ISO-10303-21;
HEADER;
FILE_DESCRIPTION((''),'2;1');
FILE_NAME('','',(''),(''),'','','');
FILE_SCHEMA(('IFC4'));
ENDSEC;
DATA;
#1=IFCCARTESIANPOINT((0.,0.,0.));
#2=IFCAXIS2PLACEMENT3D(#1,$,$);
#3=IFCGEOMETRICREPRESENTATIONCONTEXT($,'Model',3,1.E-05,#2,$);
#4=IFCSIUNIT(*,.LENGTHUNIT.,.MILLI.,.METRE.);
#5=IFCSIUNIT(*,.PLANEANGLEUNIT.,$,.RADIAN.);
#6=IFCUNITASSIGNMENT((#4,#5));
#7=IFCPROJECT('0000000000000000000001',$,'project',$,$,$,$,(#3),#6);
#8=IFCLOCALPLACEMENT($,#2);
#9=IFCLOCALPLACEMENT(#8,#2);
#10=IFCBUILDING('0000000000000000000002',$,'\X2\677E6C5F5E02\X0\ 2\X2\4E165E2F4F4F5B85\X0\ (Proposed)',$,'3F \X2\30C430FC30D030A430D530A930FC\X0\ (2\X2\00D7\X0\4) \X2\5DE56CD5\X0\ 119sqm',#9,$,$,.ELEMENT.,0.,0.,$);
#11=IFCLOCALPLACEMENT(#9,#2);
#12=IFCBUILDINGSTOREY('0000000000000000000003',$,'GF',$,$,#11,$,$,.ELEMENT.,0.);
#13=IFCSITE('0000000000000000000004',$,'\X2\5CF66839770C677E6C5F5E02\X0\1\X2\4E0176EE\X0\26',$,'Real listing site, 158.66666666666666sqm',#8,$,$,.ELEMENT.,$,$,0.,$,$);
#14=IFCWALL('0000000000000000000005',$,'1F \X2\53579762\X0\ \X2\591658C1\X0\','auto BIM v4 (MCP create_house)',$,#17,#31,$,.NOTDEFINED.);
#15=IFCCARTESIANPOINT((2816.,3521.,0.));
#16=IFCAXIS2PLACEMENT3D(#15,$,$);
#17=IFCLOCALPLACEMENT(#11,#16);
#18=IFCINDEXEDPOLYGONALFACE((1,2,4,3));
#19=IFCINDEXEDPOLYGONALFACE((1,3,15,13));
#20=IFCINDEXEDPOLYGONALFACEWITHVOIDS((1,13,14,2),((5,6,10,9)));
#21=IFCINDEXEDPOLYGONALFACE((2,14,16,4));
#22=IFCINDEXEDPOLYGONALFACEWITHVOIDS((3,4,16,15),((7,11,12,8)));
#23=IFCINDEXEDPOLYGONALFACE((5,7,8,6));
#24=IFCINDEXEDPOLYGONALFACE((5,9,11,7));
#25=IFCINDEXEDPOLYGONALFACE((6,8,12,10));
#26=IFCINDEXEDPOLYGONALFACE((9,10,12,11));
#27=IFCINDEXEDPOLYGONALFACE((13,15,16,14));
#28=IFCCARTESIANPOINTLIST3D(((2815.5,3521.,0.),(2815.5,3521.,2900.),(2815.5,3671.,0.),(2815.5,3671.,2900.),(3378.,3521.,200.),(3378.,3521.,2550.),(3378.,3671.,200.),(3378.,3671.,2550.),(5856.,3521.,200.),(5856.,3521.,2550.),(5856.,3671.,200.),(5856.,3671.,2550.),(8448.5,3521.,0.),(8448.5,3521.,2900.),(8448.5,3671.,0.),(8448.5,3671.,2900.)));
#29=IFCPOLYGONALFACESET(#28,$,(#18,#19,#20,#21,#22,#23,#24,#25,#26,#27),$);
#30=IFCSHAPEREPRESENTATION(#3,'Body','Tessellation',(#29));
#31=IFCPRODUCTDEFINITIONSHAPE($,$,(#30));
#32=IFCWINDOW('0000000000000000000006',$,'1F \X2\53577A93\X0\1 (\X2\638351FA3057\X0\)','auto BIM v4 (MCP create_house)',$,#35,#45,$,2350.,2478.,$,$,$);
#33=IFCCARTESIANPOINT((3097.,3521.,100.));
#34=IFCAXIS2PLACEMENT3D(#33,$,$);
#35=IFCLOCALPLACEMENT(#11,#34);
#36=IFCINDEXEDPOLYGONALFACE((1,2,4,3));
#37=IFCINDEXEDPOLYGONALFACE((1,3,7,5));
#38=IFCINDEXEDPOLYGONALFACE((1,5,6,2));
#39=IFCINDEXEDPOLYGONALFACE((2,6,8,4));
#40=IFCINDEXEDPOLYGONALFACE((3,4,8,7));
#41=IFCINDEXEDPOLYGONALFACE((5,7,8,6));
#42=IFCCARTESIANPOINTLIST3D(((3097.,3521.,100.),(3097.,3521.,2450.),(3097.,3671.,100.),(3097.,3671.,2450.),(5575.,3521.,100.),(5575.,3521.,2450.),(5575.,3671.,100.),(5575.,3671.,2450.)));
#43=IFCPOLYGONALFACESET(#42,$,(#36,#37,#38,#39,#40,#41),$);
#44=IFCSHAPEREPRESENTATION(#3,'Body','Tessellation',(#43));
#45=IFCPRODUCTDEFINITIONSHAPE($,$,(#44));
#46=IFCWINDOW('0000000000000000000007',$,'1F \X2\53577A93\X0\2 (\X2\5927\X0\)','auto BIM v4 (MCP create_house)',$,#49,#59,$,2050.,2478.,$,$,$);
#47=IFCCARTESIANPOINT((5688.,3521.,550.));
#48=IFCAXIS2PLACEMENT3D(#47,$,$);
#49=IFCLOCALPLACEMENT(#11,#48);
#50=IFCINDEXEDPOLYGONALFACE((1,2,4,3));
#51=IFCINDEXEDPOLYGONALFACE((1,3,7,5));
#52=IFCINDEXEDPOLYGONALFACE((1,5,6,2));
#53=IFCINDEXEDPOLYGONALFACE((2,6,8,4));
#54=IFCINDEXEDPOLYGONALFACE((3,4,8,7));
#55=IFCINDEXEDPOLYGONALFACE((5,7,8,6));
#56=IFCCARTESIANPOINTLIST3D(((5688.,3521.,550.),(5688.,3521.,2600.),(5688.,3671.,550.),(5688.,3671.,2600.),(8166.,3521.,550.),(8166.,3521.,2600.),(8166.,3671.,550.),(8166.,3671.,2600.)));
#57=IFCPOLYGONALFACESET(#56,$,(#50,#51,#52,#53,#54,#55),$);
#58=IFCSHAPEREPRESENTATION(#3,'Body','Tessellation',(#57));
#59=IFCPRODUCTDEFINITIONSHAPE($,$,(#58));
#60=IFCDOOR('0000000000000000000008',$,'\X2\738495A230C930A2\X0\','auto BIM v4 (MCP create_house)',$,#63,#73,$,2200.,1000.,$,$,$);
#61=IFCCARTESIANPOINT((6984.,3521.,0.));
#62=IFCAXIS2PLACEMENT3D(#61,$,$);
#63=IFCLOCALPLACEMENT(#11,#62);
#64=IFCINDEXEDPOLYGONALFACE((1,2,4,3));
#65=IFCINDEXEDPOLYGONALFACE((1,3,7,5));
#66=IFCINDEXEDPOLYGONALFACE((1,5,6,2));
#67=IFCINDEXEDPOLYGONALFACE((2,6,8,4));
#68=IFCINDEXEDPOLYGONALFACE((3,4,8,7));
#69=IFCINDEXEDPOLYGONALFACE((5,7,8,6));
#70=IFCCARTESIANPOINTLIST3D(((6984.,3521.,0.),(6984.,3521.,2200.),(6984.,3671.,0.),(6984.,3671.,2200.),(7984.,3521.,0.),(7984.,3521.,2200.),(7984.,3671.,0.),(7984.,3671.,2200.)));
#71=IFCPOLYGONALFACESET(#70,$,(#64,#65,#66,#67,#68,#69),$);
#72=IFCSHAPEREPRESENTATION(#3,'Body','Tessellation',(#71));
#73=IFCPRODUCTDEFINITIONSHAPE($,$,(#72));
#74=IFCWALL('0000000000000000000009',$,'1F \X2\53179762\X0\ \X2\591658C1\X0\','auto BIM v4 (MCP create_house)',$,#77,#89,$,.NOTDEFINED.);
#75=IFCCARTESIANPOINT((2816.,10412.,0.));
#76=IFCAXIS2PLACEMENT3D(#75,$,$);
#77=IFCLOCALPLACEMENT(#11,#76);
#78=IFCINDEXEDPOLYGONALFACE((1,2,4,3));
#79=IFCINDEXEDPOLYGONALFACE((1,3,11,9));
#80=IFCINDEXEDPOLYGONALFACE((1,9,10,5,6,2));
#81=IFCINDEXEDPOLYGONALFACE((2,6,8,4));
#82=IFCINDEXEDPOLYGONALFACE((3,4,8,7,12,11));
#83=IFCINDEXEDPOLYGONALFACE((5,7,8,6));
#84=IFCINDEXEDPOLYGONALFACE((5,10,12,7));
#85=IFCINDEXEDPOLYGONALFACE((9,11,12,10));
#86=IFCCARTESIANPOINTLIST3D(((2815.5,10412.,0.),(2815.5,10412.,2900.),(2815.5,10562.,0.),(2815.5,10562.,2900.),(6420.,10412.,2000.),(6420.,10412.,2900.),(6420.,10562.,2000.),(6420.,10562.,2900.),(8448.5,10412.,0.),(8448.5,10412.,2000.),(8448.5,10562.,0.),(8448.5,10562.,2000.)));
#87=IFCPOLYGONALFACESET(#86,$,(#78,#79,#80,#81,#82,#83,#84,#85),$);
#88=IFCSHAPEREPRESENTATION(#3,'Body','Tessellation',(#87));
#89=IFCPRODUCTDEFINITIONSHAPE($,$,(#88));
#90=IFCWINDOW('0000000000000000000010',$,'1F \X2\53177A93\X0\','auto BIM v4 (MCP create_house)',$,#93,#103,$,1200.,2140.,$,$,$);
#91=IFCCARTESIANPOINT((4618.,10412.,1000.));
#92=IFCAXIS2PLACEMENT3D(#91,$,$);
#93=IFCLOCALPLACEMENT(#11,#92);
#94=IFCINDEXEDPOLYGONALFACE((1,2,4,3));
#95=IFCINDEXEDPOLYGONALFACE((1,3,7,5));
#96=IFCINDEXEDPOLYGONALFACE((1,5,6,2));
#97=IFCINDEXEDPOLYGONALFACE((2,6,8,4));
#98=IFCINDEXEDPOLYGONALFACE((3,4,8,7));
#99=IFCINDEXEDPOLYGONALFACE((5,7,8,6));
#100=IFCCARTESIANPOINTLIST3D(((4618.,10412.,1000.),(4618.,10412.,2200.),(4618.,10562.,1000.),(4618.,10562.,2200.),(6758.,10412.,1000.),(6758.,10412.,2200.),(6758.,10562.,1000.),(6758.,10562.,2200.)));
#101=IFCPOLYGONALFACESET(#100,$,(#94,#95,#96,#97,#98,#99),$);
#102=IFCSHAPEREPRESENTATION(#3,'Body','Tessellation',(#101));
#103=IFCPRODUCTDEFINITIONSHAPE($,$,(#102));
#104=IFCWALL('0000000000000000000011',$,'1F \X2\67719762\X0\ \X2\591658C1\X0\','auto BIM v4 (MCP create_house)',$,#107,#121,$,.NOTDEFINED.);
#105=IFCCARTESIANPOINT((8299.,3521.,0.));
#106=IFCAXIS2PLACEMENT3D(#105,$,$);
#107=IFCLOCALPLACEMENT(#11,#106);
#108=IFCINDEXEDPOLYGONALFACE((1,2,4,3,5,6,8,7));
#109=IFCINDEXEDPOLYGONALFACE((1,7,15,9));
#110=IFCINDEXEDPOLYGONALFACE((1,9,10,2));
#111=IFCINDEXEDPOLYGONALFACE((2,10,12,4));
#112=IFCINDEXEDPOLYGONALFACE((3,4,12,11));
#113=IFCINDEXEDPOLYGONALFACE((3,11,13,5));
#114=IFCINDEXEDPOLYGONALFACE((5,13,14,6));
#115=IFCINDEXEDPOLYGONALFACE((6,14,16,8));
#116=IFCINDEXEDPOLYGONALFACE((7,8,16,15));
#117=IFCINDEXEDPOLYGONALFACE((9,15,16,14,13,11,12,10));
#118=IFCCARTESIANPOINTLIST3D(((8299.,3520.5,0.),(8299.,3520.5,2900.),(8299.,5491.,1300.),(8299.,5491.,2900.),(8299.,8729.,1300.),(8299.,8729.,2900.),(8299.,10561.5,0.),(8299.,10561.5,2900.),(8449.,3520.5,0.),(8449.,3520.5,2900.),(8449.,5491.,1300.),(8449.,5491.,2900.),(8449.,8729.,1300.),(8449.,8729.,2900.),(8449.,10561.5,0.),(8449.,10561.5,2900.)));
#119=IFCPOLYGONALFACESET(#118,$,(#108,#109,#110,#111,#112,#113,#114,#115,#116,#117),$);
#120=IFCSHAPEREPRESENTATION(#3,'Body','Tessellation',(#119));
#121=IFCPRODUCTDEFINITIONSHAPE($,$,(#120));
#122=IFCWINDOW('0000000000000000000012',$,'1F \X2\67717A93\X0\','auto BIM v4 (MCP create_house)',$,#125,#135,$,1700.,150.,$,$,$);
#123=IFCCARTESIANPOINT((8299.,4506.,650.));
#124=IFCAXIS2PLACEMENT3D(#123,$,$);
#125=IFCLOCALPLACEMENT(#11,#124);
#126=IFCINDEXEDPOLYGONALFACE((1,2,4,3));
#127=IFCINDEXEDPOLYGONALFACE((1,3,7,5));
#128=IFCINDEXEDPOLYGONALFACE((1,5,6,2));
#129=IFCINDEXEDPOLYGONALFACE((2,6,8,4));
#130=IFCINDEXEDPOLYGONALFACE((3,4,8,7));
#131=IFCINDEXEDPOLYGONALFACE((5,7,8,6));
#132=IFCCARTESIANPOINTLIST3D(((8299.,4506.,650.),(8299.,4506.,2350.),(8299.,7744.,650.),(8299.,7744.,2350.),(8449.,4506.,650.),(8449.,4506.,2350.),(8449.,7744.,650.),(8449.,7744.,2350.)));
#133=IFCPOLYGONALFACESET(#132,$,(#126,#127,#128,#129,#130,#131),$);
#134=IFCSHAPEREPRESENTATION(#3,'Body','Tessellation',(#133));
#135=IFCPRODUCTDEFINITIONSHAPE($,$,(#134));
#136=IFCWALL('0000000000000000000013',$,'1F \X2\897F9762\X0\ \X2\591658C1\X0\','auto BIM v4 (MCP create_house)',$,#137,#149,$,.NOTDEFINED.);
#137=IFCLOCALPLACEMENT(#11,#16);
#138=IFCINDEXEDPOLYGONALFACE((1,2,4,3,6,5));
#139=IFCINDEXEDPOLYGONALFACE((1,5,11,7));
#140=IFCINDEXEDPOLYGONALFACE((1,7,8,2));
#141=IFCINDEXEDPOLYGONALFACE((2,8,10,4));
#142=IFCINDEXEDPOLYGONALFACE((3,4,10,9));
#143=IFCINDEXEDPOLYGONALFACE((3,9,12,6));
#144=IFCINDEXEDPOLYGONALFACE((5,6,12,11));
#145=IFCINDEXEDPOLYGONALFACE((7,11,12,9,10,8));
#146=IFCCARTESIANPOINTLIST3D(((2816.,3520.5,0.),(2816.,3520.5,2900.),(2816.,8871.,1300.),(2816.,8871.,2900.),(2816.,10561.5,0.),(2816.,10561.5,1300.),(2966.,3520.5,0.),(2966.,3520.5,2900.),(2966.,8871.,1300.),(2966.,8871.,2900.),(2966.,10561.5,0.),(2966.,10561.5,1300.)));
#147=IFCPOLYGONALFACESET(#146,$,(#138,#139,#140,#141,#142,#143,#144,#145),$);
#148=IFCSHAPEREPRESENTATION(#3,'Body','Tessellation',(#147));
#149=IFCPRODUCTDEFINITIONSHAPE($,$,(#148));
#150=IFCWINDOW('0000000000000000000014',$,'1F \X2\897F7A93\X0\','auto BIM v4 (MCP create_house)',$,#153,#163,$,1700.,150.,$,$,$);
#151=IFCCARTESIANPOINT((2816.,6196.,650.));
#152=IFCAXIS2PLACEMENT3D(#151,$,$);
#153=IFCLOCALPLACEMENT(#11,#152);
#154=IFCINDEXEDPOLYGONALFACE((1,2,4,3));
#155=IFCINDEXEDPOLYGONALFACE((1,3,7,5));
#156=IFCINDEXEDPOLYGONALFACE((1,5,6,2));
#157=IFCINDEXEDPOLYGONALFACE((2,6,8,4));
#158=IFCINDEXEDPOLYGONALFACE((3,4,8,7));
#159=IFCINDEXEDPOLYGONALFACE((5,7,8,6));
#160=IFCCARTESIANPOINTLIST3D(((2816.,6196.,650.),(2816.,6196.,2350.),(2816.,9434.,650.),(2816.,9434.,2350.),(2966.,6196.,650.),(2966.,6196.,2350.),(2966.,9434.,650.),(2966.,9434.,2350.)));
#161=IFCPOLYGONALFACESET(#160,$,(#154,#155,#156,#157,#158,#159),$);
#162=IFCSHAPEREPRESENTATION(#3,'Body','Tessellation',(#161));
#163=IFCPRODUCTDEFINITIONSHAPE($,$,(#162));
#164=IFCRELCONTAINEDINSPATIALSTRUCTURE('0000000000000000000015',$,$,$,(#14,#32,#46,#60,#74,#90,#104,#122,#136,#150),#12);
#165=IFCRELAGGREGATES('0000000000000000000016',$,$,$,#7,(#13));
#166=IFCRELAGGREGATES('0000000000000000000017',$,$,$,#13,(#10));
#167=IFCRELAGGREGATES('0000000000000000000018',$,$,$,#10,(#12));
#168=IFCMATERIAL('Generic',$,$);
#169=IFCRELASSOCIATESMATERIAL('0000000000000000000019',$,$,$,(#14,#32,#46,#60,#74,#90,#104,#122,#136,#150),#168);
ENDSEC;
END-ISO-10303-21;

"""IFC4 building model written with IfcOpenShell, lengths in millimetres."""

from ifc_helpers import new_model, si_unit, frame, frame_2d, origin, place, context, project, spatial, rectangle, extrude, material, element, fill, save


model = new_model("IFC4")

# Units and contexts
model_context = context("Model", 3, precision=1e-05, world=origin())
ifc_project = project(units=[si_unit("LENGTHUNIT", "METRE", prefix="MILLI"), si_unit("PLANEANGLEUNIT", "RADIAN")], contexts=[model_context])

# Site, building, storey
site_placement = place(None, origin())
site = spatial("IfcSite", under=ifc_project, at=site_placement, Name="島根県松江市1丁目26", ObjectType="Real listing site, 158.66666666666666sqm", CompositionType="ELEMENT", RefElevation=0.0)
building_placement = place(site_placement, origin())
building = spatial("IfcBuilding", under=site, at=building_placement, Name="松江市 2世帯住宅 (Proposed)", ObjectType="3F ツーバイフォー (2×4) 工法 119sqm", CompositionType="ELEMENT", ElevationOfRefHeight=0.0, ElevationOfTerrain=0.0)
storey_placement = place(building_placement, origin())
storey = spatial("IfcBuildingStorey", under=building, at=storey_placement, Name="GF", CompositionType="ELEMENT", Elevation=0.0)

# Shared definitions
ifc_material = material(Name="Generic")

# Wall, openings, windows, door
wall_1_placement = place(storey_placement, frame((2816.0, 3521.0, 0.0)))
wall_1 = element("IfcWall", 1, at=wall_1_placement, inside=storey, material=ifc_material, Name="1F 南面 外壁", Description="auto BIM v4 (MCP create_house)", PredefinedType="NOTDEFINED", context=model_context, shape_type="SweptSolid", body=[
    extrude(rectangle(XDim=5633.0, YDim=150.0, at=frame_2d((2816.0, 75.0))), frame((2816.0, 3521.0, 0.0)), (0.0, 0.0, 1.0), 2900.0),
])
opening_1_placement = place(storey_placement, frame((3097.0, 3521.0, 100.0)))
opening_1 = element("IfcOpeningElement", 2, at=opening_1_placement, cuts=wall_1, PredefinedType="NOTDEFINED", context=model_context, shape_type="SweptSolid", body=[
    extrude(rectangle(XDim=2478.0, YDim=150.0, at=frame_2d((1239.0, 75.0))), frame((3097.0, 3521.0, 100.0)), (0.0, 0.0, 1.0), 2350.0),
])
opening_2_placement = place(storey_placement, frame((5688.0, 3521.0, 550.0)))
opening_2 = element("IfcOpeningElement", 3, at=opening_2_placement, cuts=wall_1, PredefinedType="NOTDEFINED", context=model_context, shape_type="SweptSolid", body=[
    extrude(rectangle(XDim=2478.0, YDim=150.0, at=frame_2d((1239.0, 75.0))), frame((5688.0, 3521.0, 550.0)), (0.0, 0.0, 1.0), 2050.0),
])
opening_3_placement = place(storey_placement, frame((6984.0, 3521.0, 0.0)))
opening_3 = element("IfcOpeningElement", 4, at=opening_3_placement, cuts=wall_1, PredefinedType="NOTDEFINED", context=model_context, shape_type="SweptSolid", body=[
    extrude(rectangle(XDim=1000.0, YDim=150.0, at=frame_2d((500.0, 75.0))), frame((6984.0, 3521.0, 0.0)), (0.0, 0.0, 1.0), 2200.0),
])
window_1_placement = place(storey_placement, frame((3097.0, 3521.0, 100.0)))
window_1 = element("IfcWindow", 5, at=window_1_placement, inside=storey, material=ifc_material, Name="1F 南窓1 (掃出し)", Description="auto BIM v4 (MCP create_house)", OverallHeight=2350.0, OverallWidth=2478.0, context=model_context, shape_type="SweptSolid", body=[
    extrude(rectangle(XDim=2478.0, YDim=150.0, at=frame_2d((1239.0, 75.0))), frame((3097.0, 3521.0, 100.0)), (0.0, 0.0, 1.0), 2350.0),
])
fill(opening_1, window_1)
window_2_placement = place(storey_placement, frame((5688.0, 3521.0, 550.0)))
window_2 = element("IfcWindow", 6, at=window_2_placement, inside=storey, material=ifc_material, Name="1F 南窓2 (大)", Description="auto BIM v4 (MCP create_house)", OverallHeight=2050.0, OverallWidth=2478.0, context=model_context, shape_type="SweptSolid", body=[
    extrude(rectangle(XDim=2478.0, YDim=150.0, at=frame_2d((1239.0, 75.0))), frame((5688.0, 3521.0, 550.0)), (0.0, 0.0, 1.0), 2050.0),
])
fill(opening_2, window_2)
door_placement = place(storey_placement, frame((6984.0, 3521.0, 0.0)))
door = element("IfcDoor", 7, at=door_placement, inside=storey, material=ifc_material, Name="玄関ドア", Description="auto BIM v4 (MCP create_house)", OverallHeight=2200.0, OverallWidth=1000.0, context=model_context, shape_type="SweptSolid", body=[
    extrude(rectangle(XDim=1000.0, YDim=150.0, at=frame_2d((500.0, 75.0))), frame((6984.0, 3521.0, 0.0)), (0.0, 0.0, 1.0), 2200.0),
])
fill(opening_3, door)

# Walls, openings, windows
wall_2_placement = place(storey_placement, frame((2816.0, 10412.0, 0.0)))
wall_2 = element("IfcWall", 8, at=wall_2_placement, inside=storey, material=ifc_material, Name="1F 北面 外壁", Description="auto BIM v4 (MCP create_house)", PredefinedType="NOTDEFINED", context=model_context, shape_type="SweptSolid", body=[
    extrude(rectangle(XDim=5633.0, YDim=150.0, at=frame_2d((2816.0, 75.0))), frame((2816.0, 10412.0, 0.0)), (0.0, 0.0, 1.0), 2900.0),
])
opening_4_placement = place(storey_placement, frame((4618.0, 10412.0, 1000.0)))
opening_4 = element("IfcOpeningElement", 9, at=opening_4_placement, cuts=wall_2, PredefinedType="NOTDEFINED", context=model_context, shape_type="SweptSolid", body=[
    extrude(rectangle(XDim=2140.0, YDim=150.0, at=frame_2d((1070.0, 75.0))), frame((4618.0, 10412.0, 1000.0)), (0.0, 0.0, 1.0), 1200.0),
])
window_3_placement = place(storey_placement, frame((4618.0, 10412.0, 1000.0)))
window_3 = element("IfcWindow", 10, at=window_3_placement, inside=storey, material=ifc_material, Name="1F 北窓", Description="auto BIM v4 (MCP create_house)", OverallHeight=1200.0, OverallWidth=2140.0, context=model_context, shape_type="SweptSolid", body=[
    extrude(rectangle(XDim=2140.0, YDim=150.0, at=frame_2d((1070.0, 75.0))), frame((4618.0, 10412.0, 1000.0)), (0.0, 0.0, 1.0), 1200.0),
])
fill(opening_4, window_3)
wall_3_placement = place(storey_placement, frame((8299.0, 3521.0, 0.0)))
wall_3 = element("IfcWall", 11, at=wall_3_placement, inside=storey, material=ifc_material, Name="1F 東面 外壁", Description="auto BIM v4 (MCP create_house)", PredefinedType="NOTDEFINED", context=model_context, shape_type="SweptSolid", body=[
    extrude(rectangle(XDim=150.0, YDim=7041.0, at=frame_2d((75.0, 3520.0))), frame((8299.0, 3521.0, 0.0)), (0.0, 0.0, 1.0), 2900.0),
])
opening_5_placement = place(storey_placement, frame((8299.0, 4506.0, 650.0)))
opening_5 = element("IfcOpeningElement", 12, at=opening_5_placement, cuts=wall_3, PredefinedType="NOTDEFINED", context=model_context, shape_type="SweptSolid", body=[
    extrude(rectangle(XDim=150.0, YDim=3238.0, at=frame_2d((75.0, 1619.0))), frame((8299.0, 4506.0, 650.0)), (0.0, 0.0, 1.0), 1700.0),
])
window_4_placement = place(storey_placement, frame((8299.0, 4506.0, 650.0)))
window_4 = element("IfcWindow", 13, at=window_4_placement, inside=storey, material=ifc_material, Name="1F 東窓", Description="auto BIM v4 (MCP create_house)", OverallHeight=1700.0, OverallWidth=150.0, context=model_context, shape_type="SweptSolid", body=[
    extrude(rectangle(XDim=150.0, YDim=3238.0, at=frame_2d((75.0, 1619.0))), frame((8299.0, 4506.0, 650.0)), (0.0, 0.0, 1.0), 1700.0),
])
fill(opening_5, window_4)
wall_4_placement = place(storey_placement, frame((2816.0, 3521.0, 0.0)))
wall_4 = element("IfcWall", 14, at=wall_4_placement, inside=storey, material=ifc_material, Name="1F 西面 外壁", Description="auto BIM v4 (MCP create_house)", PredefinedType="NOTDEFINED", context=model_context, shape_type="SweptSolid", body=[
    extrude(rectangle(XDim=150.0, YDim=7041.0, at=frame_2d((75.0, 3520.0))), frame((2816.0, 3521.0, 0.0)), (0.0, 0.0, 1.0), 2900.0),
])
opening_6_placement = place(storey_placement, frame((2816.0, 6196.0, 650.0)))
opening_6 = element("IfcOpeningElement", 15, at=opening_6_placement, cuts=wall_4, PredefinedType="NOTDEFINED", context=model_context, shape_type="SweptSolid", body=[
    extrude(rectangle(XDim=150.0, YDim=3238.0, at=frame_2d((75.0, 1619.0))), frame((2816.0, 6196.0, 650.0)), (0.0, 0.0, 1.0), 1700.0),
])
window_5_placement = place(storey_placement, frame((2816.0, 6196.0, 650.0)))
window_5 = element("IfcWindow", 16, at=window_5_placement, inside=storey, material=ifc_material, Name="1F 西窓", Description="auto BIM v4 (MCP create_house)", OverallHeight=1700.0, OverallWidth=150.0, context=model_context, shape_type="SweptSolid", body=[
    extrude(rectangle(XDim=150.0, YDim=3238.0, at=frame_2d((75.0, 1619.0))), frame((2816.0, 6196.0, 650.0)), (0.0, 0.0, 1.0), 1700.0),
])
fill(opening_6, window_5)

save(model, "model.ifc")
